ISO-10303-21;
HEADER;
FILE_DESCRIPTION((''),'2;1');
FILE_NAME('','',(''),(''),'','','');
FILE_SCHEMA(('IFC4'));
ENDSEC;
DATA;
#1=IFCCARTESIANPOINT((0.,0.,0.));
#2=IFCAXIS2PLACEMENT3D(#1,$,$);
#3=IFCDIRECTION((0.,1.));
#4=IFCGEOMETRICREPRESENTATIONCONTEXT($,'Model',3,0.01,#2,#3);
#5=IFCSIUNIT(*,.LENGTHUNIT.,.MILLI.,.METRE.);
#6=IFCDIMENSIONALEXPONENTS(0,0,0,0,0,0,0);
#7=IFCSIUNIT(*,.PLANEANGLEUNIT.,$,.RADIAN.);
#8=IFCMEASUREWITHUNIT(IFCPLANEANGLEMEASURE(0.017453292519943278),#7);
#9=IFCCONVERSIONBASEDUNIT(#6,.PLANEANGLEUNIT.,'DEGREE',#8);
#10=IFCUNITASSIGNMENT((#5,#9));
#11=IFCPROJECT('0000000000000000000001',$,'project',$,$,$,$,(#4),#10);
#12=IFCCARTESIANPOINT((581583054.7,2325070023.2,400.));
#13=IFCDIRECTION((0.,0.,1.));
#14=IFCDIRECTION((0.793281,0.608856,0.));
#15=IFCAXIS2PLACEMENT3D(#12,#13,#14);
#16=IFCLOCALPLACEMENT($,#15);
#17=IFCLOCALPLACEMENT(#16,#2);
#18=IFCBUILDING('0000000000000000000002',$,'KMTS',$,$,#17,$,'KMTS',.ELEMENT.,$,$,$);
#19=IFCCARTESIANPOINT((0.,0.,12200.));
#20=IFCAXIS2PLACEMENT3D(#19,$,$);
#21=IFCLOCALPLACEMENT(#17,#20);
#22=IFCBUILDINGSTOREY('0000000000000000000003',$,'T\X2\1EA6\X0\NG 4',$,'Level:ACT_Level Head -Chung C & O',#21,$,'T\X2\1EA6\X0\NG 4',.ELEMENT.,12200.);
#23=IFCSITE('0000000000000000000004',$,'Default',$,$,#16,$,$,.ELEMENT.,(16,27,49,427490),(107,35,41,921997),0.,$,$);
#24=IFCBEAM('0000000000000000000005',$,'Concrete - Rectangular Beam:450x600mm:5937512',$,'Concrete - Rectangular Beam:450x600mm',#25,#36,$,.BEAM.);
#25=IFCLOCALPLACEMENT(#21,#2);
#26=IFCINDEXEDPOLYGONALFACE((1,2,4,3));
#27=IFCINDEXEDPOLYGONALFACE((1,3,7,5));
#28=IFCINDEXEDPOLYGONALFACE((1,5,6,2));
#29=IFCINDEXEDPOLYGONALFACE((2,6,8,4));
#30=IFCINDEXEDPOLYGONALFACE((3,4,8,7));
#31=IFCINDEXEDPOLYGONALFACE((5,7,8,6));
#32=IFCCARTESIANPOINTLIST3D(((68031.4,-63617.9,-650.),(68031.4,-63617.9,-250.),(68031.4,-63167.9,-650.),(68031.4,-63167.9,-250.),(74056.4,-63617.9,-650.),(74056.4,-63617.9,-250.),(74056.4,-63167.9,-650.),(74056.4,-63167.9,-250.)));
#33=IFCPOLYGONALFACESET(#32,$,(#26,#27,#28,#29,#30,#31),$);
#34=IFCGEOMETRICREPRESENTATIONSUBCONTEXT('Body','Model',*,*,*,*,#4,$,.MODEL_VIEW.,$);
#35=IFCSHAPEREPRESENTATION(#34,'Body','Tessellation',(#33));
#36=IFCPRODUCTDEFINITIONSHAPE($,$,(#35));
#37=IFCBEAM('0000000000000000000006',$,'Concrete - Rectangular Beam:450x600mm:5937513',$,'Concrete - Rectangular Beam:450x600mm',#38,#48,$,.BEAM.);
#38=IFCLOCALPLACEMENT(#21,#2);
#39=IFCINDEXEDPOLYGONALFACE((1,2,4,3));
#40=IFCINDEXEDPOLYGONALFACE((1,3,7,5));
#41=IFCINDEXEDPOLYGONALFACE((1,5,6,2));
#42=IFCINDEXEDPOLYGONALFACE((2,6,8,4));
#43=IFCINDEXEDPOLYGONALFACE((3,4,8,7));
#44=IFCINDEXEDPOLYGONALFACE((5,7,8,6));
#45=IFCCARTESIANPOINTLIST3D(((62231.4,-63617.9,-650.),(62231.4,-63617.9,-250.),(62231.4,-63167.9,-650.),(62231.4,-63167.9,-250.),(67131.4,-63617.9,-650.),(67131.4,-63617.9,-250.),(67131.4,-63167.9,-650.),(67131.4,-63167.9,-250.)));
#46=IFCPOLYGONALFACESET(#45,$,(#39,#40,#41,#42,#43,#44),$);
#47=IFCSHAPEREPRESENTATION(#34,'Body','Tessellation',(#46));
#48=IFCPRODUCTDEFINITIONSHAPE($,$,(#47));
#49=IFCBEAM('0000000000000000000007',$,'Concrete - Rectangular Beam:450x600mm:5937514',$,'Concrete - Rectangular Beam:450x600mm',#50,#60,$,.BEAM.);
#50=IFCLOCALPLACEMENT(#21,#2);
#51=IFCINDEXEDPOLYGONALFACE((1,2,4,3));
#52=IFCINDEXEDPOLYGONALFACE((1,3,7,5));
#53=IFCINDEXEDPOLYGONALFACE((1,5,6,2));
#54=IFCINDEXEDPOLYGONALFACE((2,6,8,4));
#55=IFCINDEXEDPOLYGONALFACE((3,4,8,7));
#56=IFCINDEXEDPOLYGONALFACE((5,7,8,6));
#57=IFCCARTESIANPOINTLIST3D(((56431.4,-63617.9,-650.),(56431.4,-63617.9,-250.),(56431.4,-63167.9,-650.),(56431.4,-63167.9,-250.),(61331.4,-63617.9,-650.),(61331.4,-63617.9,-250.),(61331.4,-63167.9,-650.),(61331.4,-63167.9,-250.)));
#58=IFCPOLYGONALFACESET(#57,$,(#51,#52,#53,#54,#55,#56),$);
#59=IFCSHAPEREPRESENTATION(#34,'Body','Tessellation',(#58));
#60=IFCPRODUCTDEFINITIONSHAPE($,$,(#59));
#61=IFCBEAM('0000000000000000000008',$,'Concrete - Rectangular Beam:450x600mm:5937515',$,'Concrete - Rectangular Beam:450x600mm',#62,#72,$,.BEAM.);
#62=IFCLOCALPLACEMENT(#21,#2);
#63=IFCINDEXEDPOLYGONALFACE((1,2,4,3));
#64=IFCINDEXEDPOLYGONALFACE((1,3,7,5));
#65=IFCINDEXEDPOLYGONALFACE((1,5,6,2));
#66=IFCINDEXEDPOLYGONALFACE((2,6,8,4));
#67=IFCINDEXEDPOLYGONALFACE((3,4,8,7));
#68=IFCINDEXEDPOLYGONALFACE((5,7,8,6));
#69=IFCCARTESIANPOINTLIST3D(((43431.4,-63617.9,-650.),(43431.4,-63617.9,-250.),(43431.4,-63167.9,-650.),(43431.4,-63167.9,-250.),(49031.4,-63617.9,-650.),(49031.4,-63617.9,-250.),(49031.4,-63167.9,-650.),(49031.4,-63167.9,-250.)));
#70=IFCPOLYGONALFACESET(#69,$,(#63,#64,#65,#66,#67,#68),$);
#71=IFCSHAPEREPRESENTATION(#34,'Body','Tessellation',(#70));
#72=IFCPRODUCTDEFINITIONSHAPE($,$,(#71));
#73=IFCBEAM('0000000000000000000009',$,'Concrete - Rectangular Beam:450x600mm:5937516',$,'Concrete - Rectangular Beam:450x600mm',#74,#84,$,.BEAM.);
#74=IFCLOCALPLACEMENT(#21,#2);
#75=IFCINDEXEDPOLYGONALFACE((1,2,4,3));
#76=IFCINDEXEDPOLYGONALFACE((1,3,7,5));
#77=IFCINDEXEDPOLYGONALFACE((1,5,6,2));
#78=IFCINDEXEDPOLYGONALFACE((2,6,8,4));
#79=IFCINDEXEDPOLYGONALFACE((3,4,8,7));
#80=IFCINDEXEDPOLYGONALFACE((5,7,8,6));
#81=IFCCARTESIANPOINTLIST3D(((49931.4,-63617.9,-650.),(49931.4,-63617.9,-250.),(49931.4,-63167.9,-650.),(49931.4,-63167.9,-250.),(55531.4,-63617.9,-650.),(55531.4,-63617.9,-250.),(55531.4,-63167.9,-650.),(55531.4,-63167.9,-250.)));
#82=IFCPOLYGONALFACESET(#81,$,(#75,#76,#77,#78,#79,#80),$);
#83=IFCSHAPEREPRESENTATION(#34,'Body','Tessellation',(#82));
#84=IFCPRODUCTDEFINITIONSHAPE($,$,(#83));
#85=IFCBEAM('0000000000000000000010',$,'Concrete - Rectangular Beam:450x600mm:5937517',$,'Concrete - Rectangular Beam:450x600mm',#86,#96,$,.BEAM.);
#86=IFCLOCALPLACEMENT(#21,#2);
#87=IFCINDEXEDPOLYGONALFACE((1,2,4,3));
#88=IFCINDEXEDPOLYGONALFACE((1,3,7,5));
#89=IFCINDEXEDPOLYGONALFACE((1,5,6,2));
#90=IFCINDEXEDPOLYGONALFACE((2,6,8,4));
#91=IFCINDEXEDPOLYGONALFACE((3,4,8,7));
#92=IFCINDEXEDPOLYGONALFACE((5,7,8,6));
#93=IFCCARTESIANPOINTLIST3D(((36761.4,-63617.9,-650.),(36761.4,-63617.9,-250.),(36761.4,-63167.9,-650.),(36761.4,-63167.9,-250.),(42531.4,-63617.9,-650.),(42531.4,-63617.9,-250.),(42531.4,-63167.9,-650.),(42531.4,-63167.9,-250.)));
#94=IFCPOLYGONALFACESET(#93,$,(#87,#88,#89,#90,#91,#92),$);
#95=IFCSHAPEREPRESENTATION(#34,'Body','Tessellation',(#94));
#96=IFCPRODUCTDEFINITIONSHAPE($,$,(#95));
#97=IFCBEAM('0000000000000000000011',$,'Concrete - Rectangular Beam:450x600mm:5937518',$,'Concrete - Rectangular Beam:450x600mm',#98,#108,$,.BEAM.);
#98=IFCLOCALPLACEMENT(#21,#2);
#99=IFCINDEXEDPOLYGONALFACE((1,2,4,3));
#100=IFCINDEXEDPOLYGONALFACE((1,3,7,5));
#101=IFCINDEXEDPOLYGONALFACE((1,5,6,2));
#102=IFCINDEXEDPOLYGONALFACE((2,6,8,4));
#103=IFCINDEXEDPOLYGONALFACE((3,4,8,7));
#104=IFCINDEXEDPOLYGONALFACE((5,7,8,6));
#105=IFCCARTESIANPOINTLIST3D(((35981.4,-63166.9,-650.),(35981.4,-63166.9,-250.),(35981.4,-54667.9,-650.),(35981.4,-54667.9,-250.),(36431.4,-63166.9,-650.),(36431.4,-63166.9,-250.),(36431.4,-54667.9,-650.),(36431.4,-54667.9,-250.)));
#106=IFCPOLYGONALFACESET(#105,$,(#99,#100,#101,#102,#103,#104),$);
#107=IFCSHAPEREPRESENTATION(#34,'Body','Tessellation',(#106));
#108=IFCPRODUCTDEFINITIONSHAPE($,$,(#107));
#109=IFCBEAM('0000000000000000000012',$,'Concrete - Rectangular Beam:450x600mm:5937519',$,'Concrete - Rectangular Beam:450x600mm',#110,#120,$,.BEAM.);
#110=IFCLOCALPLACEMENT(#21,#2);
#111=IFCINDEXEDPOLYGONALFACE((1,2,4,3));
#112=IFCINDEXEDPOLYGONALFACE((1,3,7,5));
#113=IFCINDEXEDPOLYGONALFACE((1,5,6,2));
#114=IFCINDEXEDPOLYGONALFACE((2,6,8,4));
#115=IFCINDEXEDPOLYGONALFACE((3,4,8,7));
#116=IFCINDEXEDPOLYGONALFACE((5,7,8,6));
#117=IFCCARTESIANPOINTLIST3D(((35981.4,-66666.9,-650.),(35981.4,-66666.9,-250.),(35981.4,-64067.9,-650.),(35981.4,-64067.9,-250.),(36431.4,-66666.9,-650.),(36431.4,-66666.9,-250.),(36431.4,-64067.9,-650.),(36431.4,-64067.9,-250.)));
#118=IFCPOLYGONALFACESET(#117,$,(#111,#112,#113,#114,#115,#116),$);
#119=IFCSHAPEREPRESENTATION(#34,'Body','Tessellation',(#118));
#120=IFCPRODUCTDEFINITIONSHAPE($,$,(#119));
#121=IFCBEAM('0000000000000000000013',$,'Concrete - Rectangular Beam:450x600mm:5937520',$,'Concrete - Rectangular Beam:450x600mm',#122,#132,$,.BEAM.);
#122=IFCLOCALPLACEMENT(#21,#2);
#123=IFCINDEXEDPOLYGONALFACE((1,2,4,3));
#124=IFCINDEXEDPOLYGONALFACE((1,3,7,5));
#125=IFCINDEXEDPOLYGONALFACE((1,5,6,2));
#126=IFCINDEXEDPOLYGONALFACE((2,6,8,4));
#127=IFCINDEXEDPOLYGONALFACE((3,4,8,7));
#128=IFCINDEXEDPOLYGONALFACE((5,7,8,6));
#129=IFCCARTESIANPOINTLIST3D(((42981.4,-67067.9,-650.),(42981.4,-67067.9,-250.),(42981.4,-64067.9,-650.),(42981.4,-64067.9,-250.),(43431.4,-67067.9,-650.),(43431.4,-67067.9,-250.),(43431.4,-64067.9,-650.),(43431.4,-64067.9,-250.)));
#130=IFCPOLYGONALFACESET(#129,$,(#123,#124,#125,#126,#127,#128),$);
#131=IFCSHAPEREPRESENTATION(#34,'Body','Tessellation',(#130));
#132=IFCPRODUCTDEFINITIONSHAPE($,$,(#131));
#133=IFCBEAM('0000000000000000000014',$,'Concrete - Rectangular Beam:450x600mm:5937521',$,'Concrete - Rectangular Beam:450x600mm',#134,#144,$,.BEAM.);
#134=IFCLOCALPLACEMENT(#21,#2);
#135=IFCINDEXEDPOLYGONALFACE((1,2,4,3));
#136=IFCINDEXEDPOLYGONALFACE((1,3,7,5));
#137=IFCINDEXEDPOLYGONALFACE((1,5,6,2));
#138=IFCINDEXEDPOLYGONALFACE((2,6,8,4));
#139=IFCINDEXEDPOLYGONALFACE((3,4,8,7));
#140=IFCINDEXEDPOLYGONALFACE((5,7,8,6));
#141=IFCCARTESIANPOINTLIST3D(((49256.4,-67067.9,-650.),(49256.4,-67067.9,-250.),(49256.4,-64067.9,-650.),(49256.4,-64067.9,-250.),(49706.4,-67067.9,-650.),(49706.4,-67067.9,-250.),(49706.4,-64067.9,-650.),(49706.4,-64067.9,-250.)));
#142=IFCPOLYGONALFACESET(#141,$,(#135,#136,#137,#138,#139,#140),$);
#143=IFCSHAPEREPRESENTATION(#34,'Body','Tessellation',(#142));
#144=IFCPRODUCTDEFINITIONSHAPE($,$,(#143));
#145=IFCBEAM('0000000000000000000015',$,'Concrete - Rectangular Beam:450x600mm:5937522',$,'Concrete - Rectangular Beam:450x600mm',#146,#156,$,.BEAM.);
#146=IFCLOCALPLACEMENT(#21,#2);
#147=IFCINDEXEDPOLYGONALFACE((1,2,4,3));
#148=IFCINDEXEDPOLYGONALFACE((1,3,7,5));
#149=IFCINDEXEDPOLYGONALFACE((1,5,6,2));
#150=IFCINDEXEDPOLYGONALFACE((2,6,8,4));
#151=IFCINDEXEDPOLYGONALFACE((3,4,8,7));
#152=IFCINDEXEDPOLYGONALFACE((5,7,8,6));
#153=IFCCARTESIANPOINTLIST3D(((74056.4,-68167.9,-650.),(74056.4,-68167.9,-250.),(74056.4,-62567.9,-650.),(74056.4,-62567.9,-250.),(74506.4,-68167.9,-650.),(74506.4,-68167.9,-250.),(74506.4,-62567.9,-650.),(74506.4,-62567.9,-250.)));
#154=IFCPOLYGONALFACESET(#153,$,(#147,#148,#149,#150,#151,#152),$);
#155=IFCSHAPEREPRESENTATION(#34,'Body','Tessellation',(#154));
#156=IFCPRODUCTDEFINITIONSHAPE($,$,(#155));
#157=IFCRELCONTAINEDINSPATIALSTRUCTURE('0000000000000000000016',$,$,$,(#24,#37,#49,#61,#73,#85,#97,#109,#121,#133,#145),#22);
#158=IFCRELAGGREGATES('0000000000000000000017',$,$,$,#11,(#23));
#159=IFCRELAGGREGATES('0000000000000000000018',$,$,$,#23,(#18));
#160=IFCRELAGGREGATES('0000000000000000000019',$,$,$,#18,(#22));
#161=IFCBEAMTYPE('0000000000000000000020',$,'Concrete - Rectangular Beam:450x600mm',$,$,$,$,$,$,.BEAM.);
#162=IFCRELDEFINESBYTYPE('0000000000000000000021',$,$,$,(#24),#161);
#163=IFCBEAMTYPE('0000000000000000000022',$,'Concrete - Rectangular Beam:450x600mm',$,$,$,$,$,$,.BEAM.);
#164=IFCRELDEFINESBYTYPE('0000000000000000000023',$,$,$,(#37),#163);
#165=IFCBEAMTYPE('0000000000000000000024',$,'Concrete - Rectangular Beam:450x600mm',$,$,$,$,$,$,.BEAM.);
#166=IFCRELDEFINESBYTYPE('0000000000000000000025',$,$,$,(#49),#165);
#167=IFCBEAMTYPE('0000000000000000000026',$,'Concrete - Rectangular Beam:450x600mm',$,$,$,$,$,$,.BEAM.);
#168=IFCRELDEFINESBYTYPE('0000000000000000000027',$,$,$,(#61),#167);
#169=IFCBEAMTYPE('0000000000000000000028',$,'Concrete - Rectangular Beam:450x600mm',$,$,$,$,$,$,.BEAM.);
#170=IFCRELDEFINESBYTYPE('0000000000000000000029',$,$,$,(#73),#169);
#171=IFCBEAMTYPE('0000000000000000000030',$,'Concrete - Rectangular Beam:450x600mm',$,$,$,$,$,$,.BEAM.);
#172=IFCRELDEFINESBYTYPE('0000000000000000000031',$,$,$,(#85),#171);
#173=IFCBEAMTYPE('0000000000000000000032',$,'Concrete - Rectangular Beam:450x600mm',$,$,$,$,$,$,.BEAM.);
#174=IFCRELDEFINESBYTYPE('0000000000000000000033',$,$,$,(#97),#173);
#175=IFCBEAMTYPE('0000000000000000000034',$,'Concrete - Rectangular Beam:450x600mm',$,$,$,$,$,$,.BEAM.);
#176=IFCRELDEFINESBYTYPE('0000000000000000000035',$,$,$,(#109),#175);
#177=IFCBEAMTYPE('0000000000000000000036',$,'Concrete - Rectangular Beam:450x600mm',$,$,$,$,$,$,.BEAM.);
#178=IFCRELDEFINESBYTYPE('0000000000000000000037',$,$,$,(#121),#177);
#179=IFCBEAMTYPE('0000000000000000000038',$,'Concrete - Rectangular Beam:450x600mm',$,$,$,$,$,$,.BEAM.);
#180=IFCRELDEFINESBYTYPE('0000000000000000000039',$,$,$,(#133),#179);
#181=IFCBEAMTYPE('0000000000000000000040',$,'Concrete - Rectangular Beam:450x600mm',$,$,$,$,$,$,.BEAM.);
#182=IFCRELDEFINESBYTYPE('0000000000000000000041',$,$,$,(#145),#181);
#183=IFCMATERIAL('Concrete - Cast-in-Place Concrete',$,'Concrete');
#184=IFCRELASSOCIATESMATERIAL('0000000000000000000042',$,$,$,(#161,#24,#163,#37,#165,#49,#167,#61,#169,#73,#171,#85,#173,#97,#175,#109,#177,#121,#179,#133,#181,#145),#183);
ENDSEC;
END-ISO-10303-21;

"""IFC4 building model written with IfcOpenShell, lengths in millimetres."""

from ifc_helpers import new_model, entity, si_unit, converted_unit, direction, frame, origin, place, context, subcontext, project, spatial, indexed_curve, outline, extrude, source, transform, mapped, material, type_object, type_shapes, element, save


model = new_model("IFC4")

# Units and contexts
model_context = context("Model", 3, precision=0.01, world=origin(), true_north=direction((0.0, 1.0)))
body_context = subcontext(model_context, "Body", "Model", "MODEL_VIEW")
ifc_project = project(units=[si_unit("LENGTHUNIT", "METRE", prefix="MILLI"), converted_unit("PLANEANGLEUNIT", "DEGREE", entity("IfcPlaneAngleMeasure", 0.017453292519943278), si_unit("PLANEANGLEUNIT", "RADIAN"), dimensions=[0, 0, 0, 0, 0, 0, 0])], contexts=[model_context])

# Site, building, storey
site_placement = place(None, frame((581583054.7, 2325070023.2, 400.0), z_axis=(0.0, 0.0, 1.0), x_axis=(0.793281, 0.608856, 0.0)))
site = spatial("IfcSite", under=ifc_project, at=site_placement, Name="Default", CompositionType="ELEMENT", RefLatitude=(16, 27, 49, 427490), RefLongitude=(107, 35, 41, 921997), RefElevation=0.0)
building_placement = place(site_placement, origin())
building = spatial("IfcBuilding", under=site, at=building_placement, Name="KMTS", LongName="KMTS", CompositionType="ELEMENT")
storey_placement = place(building_placement, frame((0.0, 0.0, 12200.0)))
storey = spatial("IfcBuildingStorey", under=building, at=storey_placement, Name="TẦNG 4", ObjectType="Level:ACT_Level Head -Chung C & O", LongName="TẦNG 4", CompositionType="ELEMENT", Elevation=12200.0)

# Beams
ifc_material_1 = material(Name="Concrete - Cast-in-Place Concrete", Category="Concrete")
beam_type_1 = type_object("IfcBeamType", Name="Concrete - Rectangular Beam:450x600mm", PredefinedType="BEAM", material=ifc_material_1)
shared_shape_1 = source(origin(), body_context, "Body", "SweptSolid", [
    extrude(outline(indexed_curve([(-200.0, -225.0), (200.0, -225.0), (200.0, 225.0), (-200.0, 225.0), (-200.0, -225.0)], self_intersect=False)), frame((68031.4, -63392.9, 11750.0), z_axis=(1.0, 0.0, 0.0), x_axis=(0.0, 0.0, -1.0)), (0.0, 0.0, 1.0), 6025.0),
])
type_shapes(beam_type_1, [shared_shape_1])
beam_1_placement = place(storey_placement, frame((0.0, 0.0, -12200.0)))
element("IfcBeam", 1, at=beam_1_placement, inside=storey, type_object=beam_type_1, material=ifc_material_1, Name="Concrete - Rectangular Beam:450x600mm:5937512", ObjectType="Concrete - Rectangular Beam:450x600mm", PredefinedType="BEAM", context=body_context, shape_type="MappedRepresentation", body=[
    mapped(shared_shape_1, transform((0.0, 0.0, 0.0), scale=1.0)),
])
beam_type_2 = type_object("IfcBeamType", Name="Concrete - Rectangular Beam:450x600mm", PredefinedType="BEAM", material=ifc_material_1)
shared_shape_2 = source(origin(), body_context, "Body", "SweptSolid", [
    extrude(outline(indexed_curve([(-200.0, -225.0), (200.0, -225.0), (200.0, 225.0), (-200.0, 225.0), (-200.0, -225.0)], self_intersect=False)), frame((62231.4, -63392.9, 11750.0), z_axis=(1.0, 0.0, 0.0), x_axis=(0.0, 0.0, -1.0)), (0.0, 0.0, 1.0), 4900.0),
])
type_shapes(beam_type_2, [shared_shape_2])
beam_2_placement = place(storey_placement, frame((0.0, 0.0, -12200.0)))
element("IfcBeam", 2, at=beam_2_placement, inside=storey, type_object=beam_type_2, material=ifc_material_1, Name="Concrete - Rectangular Beam:450x600mm:5937513", ObjectType="Concrete - Rectangular Beam:450x600mm", PredefinedType="BEAM", context=body_context, shape_type="MappedRepresentation", body=[
    mapped(shared_shape_2, transform((0.0, 0.0, 0.0), scale=1.0)),
])
beam_type_3 = type_object("IfcBeamType", Name="Concrete - Rectangular Beam:450x600mm", PredefinedType="BEAM", material=ifc_material_1)
shared_shape_3 = source(origin(), body_context, "Body", "SweptSolid", [
    extrude(outline(indexed_curve([(-200.0, -225.0), (200.0, -225.0), (200.0, 225.0), (-200.0, 225.0), (-200.0, -225.0)], self_intersect=False)), frame((56431.4, -63392.9, 11750.0), z_axis=(1.0, 0.0, 0.0), x_axis=(0.0, 0.0, -1.0)), (0.0, 0.0, 1.0), 4900.0),
])
type_shapes(beam_type_3, [shared_shape_3])
beam_3_placement = place(storey_placement, frame((0.0, 0.0, -12200.0)))
element("IfcBeam", 3, at=beam_3_placement, inside=storey, type_object=beam_type_3, material=ifc_material_1, Name="Concrete - Rectangular Beam:450x600mm:5937514", ObjectType="Concrete - Rectangular Beam:450x600mm", PredefinedType="BEAM", context=body_context, shape_type="MappedRepresentation", body=[
    mapped(shared_shape_3, transform((0.0, 0.0, 0.0), scale=1.0)),
])
beam_type_4 = type_object("IfcBeamType", Name="Concrete - Rectangular Beam:450x600mm", PredefinedType="BEAM", material=ifc_material_1)
shared_shape_4 = source(origin(), body_context, "Body", "SweptSolid", [
    extrude(outline(indexed_curve([(-200.0, -225.0), (200.0, -225.0), (200.0, 225.0), (-200.0, 225.0), (-200.0, -225.0)], self_intersect=False)), frame((43431.4, -63392.9, 11750.0), z_axis=(1.0, 0.0, 0.0), x_axis=(0.0, 0.0, -1.0)), (0.0, 0.0, 1.0), 5600.0),
])
type_shapes(beam_type_4, [shared_shape_4])
beam_4_placement = place(storey_placement, frame((0.0, 0.0, -12200.0)))
element("IfcBeam", 4, at=beam_4_placement, inside=storey, type_object=beam_type_4, material=ifc_material_1, Name="Concrete - Rectangular Beam:450x600mm:5937515", ObjectType="Concrete - Rectangular Beam:450x600mm", PredefinedType="BEAM", context=body_context, shape_type="MappedRepresentation", body=[
    mapped(shared_shape_4, transform((0.0, 0.0, 0.0), scale=1.0)),
])
beam_type_5 = type_object("IfcBeamType", Name="Concrete - Rectangular Beam:450x600mm", PredefinedType="BEAM", material=ifc_material_1)
shared_shape_5 = source(origin(), body_context, "Body", "SweptSolid", [
    extrude(outline(indexed_curve([(-200.0, -225.0), (200.0, -225.0), (200.0, 225.0), (-200.0, 225.0), (-200.0, -225.0)], self_intersect=False)), frame((49931.4, -63392.9, 11750.0), z_axis=(1.0, 0.0, 0.0), x_axis=(0.0, 0.0, -1.0)), (0.0, 0.0, 1.0), 5600.0),
])
type_shapes(beam_type_5, [shared_shape_5])
beam_5_placement = place(storey_placement, frame((0.0, 0.0, -12200.0)))
element("IfcBeam", 5, at=beam_5_placement, inside=storey, type_object=beam_type_5, material=ifc_material_1, Name="Concrete - Rectangular Beam:450x600mm:5937516", ObjectType="Concrete - Rectangular Beam:450x600mm", PredefinedType="BEAM", context=body_context, shape_type="MappedRepresentation", body=[
    mapped(shared_shape_5, transform((0.0, 0.0, 0.0), scale=1.0)),
])
beam_type_6 = type_object("IfcBeamType", Name="Concrete - Rectangular Beam:450x600mm", PredefinedType="BEAM", material=ifc_material_1)
shared_shape_6 = source(origin(), body_context, "Body", "SweptSolid", [
    extrude(outline(indexed_curve([(-200.0, -225.0), (200.0, -225.0), (200.0, 225.0), (-200.0, 225.0), (-200.0, -225.0)], self_intersect=False)), frame((36761.4, -63392.9, 11750.0), z_axis=(1.0, 0.0, 0.0), x_axis=(0.0, 0.0, -1.0)), (0.0, 0.0, 1.0), 5770.0),
])
type_shapes(beam_type_6, [shared_shape_6])
beam_6_placement = place(storey_placement, frame((0.0, 0.0, -12200.0)))
element("IfcBeam", 6, at=beam_6_placement, inside=storey, type_object=beam_type_6, material=ifc_material_1, Name="Concrete - Rectangular Beam:450x600mm:5937517", ObjectType="Concrete - Rectangular Beam:450x600mm", PredefinedType="BEAM", context=body_context, shape_type="MappedRepresentation", body=[
    mapped(shared_shape_6, transform((0.0, 0.0, 0.0), scale=1.0)),
])
beam_type_7 = type_object("IfcBeamType", Name="Concrete - Rectangular Beam:450x600mm", PredefinedType="BEAM", material=ifc_material_1)
shared_shape_7 = source(origin(), body_context, "Body", "SweptSolid", [
    extrude(outline(indexed_curve([(-225.0, -200.0), (225.0, -200.0), (225.0, 200.0), (-225.0, 200.0), (-225.0, -200.0)], self_intersect=False)), frame((36206.4, -54667.9, 11750.0), z_axis=(0.0, -1.0, 0.0), x_axis=(-1.0, 0.0, 0.0)), (0.0, 0.0, 1.0), 8499.0),
])
type_shapes(beam_type_7, [shared_shape_7])
beam_7_placement = place(storey_placement, frame((0.0, 0.0, -12200.0)))
element("IfcBeam", 7, at=beam_7_placement, inside=storey, type_object=beam_type_7, material=ifc_material_1, Name="Concrete - Rectangular Beam:450x600mm:5937518", ObjectType="Concrete - Rectangular Beam:450x600mm", PredefinedType="BEAM", context=body_context, shape_type="MappedRepresentation", body=[
    mapped(shared_shape_7, transform((0.0, 0.0, 0.0), scale=1.0)),
])
beam_type_8 = type_object("IfcBeamType", Name="Concrete - Rectangular Beam:450x600mm", PredefinedType="BEAM", material=ifc_material_1)
shared_shape_8 = source(origin(), body_context, "Body", "SweptSolid", [
    extrude(outline(indexed_curve([(-225.0, -200.0), (225.0, -200.0), (225.0, 200.0), (-225.0, 200.0), (-225.0, -200.0)], self_intersect=False)), frame((36206.4, -66666.9, 11750.0), z_axis=(0.0, 1.0, 0.0), x_axis=(-1.0, 0.0, 0.0)), (0.0, 0.0, 1.0), 2599.0),
])
type_shapes(beam_type_8, [shared_shape_8])
beam_8_placement = place(storey_placement, frame((0.0, 0.0, -12200.0)))
element("IfcBeam", 8, at=beam_8_placement, inside=storey, type_object=beam_type_8, material=ifc_material_1, Name="Concrete - Rectangular Beam:450x600mm:5937519", ObjectType="Concrete - Rectangular Beam:450x600mm", PredefinedType="BEAM", context=body_context, shape_type="MappedRepresentation", body=[
    mapped(shared_shape_8, transform((0.0, 0.0, 0.0), scale=1.0)),
])
beam_type_9 = type_object("IfcBeamType", Name="Concrete - Rectangular Beam:450x600mm", PredefinedType="BEAM", material=ifc_material_1)
shared_shape_9 = source(origin(), body_context, "Body", "SweptSolid", [
    extrude(outline(indexed_curve([(-225.0, -200.0), (225.0, -200.0), (225.0, 200.0), (-225.0, 200.0), (-225.0, -200.0)], self_intersect=False)), frame((43206.4, -67067.9, 11750.0), z_axis=(0.0, 1.0, 0.0), x_axis=(-1.0, 0.0, 0.0)), (0.0, 0.0, 1.0), 3000.0),
])
type_shapes(beam_type_9, [shared_shape_9])
beam_9_placement = place(storey_placement, frame((0.0, 0.0, -12200.0)))
element("IfcBeam", 9, at=beam_9_placement, inside=storey, type_object=beam_type_9, material=ifc_material_1, Name="Concrete - Rectangular Beam:450x600mm:5937520", ObjectType="Concrete - Rectangular Beam:450x600mm", PredefinedType="BEAM", context=body_context, shape_type="MappedRepresentation", body=[
    mapped(shared_shape_9, transform((0.0, 0.0, 0.0), scale=1.0)),
])
beam_type_10 = type_object("IfcBeamType", Name="Concrete - Rectangular Beam:450x600mm", PredefinedType="BEAM", material=ifc_material_1)
shared_shape_10 = source(origin(), body_context, "Body", "SweptSolid", [
    extrude(outline(indexed_curve([(-225.0, -200.0), (225.0, -200.0), (225.0, 200.0), (-225.0, 200.0), (-225.0, -200.0)], self_intersect=False)), frame((49481.4, -67067.9, 11750.0), z_axis=(0.0, 1.0, 0.0), x_axis=(-1.0, 0.0, 0.0)), (0.0, 0.0, 1.0), 3000.0),
])
type_shapes(beam_type_10, [shared_shape_10])
beam_10_placement = place(storey_placement, frame((0.0, 0.0, -12200.0)))
element("IfcBeam", 10, at=beam_10_placement, inside=storey, type_object=beam_type_10, material=ifc_material_1, Name="Concrete - Rectangular Beam:450x600mm:5937521", ObjectType="Concrete - Rectangular Beam:450x600mm", PredefinedType="BEAM", context=body_context, shape_type="MappedRepresentation", body=[
    mapped(shared_shape_10, transform((0.0, 0.0, 0.0), scale=1.0)),
])
beam_type_11 = type_object("IfcBeamType", Name="Concrete - Rectangular Beam:450x600mm", PredefinedType="BEAM", material=ifc_material_1)
shared_shape_11 = source(origin(), body_context, "Body", "SweptSolid", [
    extrude(outline(indexed_curve([(-225.0, -200.0), (225.0, -200.0), (225.0, 200.0), (-225.0, 200.0), (-225.0, -200.0)], self_intersect=False)), frame((74281.4, -68167.9, 11750.0), z_axis=(0.0, 1.0, 0.0), x_axis=(-1.0, 0.0, 0.0)), (0.0, 0.0, 1.0), 5600.0),
])
type_shapes(beam_type_11, [shared_shape_11])
beam_11_placement = place(storey_placement, frame((0.0, 0.0, -12200.0)))
element("IfcBeam", 11, at=beam_11_placement, inside=storey, type_object=beam_type_11, material=ifc_material_1, Name="Concrete - Rectangular Beam:450x600mm:5937522", ObjectType="Concrete - Rectangular Beam:450x600mm", PredefinedType="BEAM", context=body_context, shape_type="MappedRepresentation", body=[
    mapped(shared_shape_11, transform((0.0, 0.0, 0.0), scale=1.0)),
])

save(model, "model.ifc")
